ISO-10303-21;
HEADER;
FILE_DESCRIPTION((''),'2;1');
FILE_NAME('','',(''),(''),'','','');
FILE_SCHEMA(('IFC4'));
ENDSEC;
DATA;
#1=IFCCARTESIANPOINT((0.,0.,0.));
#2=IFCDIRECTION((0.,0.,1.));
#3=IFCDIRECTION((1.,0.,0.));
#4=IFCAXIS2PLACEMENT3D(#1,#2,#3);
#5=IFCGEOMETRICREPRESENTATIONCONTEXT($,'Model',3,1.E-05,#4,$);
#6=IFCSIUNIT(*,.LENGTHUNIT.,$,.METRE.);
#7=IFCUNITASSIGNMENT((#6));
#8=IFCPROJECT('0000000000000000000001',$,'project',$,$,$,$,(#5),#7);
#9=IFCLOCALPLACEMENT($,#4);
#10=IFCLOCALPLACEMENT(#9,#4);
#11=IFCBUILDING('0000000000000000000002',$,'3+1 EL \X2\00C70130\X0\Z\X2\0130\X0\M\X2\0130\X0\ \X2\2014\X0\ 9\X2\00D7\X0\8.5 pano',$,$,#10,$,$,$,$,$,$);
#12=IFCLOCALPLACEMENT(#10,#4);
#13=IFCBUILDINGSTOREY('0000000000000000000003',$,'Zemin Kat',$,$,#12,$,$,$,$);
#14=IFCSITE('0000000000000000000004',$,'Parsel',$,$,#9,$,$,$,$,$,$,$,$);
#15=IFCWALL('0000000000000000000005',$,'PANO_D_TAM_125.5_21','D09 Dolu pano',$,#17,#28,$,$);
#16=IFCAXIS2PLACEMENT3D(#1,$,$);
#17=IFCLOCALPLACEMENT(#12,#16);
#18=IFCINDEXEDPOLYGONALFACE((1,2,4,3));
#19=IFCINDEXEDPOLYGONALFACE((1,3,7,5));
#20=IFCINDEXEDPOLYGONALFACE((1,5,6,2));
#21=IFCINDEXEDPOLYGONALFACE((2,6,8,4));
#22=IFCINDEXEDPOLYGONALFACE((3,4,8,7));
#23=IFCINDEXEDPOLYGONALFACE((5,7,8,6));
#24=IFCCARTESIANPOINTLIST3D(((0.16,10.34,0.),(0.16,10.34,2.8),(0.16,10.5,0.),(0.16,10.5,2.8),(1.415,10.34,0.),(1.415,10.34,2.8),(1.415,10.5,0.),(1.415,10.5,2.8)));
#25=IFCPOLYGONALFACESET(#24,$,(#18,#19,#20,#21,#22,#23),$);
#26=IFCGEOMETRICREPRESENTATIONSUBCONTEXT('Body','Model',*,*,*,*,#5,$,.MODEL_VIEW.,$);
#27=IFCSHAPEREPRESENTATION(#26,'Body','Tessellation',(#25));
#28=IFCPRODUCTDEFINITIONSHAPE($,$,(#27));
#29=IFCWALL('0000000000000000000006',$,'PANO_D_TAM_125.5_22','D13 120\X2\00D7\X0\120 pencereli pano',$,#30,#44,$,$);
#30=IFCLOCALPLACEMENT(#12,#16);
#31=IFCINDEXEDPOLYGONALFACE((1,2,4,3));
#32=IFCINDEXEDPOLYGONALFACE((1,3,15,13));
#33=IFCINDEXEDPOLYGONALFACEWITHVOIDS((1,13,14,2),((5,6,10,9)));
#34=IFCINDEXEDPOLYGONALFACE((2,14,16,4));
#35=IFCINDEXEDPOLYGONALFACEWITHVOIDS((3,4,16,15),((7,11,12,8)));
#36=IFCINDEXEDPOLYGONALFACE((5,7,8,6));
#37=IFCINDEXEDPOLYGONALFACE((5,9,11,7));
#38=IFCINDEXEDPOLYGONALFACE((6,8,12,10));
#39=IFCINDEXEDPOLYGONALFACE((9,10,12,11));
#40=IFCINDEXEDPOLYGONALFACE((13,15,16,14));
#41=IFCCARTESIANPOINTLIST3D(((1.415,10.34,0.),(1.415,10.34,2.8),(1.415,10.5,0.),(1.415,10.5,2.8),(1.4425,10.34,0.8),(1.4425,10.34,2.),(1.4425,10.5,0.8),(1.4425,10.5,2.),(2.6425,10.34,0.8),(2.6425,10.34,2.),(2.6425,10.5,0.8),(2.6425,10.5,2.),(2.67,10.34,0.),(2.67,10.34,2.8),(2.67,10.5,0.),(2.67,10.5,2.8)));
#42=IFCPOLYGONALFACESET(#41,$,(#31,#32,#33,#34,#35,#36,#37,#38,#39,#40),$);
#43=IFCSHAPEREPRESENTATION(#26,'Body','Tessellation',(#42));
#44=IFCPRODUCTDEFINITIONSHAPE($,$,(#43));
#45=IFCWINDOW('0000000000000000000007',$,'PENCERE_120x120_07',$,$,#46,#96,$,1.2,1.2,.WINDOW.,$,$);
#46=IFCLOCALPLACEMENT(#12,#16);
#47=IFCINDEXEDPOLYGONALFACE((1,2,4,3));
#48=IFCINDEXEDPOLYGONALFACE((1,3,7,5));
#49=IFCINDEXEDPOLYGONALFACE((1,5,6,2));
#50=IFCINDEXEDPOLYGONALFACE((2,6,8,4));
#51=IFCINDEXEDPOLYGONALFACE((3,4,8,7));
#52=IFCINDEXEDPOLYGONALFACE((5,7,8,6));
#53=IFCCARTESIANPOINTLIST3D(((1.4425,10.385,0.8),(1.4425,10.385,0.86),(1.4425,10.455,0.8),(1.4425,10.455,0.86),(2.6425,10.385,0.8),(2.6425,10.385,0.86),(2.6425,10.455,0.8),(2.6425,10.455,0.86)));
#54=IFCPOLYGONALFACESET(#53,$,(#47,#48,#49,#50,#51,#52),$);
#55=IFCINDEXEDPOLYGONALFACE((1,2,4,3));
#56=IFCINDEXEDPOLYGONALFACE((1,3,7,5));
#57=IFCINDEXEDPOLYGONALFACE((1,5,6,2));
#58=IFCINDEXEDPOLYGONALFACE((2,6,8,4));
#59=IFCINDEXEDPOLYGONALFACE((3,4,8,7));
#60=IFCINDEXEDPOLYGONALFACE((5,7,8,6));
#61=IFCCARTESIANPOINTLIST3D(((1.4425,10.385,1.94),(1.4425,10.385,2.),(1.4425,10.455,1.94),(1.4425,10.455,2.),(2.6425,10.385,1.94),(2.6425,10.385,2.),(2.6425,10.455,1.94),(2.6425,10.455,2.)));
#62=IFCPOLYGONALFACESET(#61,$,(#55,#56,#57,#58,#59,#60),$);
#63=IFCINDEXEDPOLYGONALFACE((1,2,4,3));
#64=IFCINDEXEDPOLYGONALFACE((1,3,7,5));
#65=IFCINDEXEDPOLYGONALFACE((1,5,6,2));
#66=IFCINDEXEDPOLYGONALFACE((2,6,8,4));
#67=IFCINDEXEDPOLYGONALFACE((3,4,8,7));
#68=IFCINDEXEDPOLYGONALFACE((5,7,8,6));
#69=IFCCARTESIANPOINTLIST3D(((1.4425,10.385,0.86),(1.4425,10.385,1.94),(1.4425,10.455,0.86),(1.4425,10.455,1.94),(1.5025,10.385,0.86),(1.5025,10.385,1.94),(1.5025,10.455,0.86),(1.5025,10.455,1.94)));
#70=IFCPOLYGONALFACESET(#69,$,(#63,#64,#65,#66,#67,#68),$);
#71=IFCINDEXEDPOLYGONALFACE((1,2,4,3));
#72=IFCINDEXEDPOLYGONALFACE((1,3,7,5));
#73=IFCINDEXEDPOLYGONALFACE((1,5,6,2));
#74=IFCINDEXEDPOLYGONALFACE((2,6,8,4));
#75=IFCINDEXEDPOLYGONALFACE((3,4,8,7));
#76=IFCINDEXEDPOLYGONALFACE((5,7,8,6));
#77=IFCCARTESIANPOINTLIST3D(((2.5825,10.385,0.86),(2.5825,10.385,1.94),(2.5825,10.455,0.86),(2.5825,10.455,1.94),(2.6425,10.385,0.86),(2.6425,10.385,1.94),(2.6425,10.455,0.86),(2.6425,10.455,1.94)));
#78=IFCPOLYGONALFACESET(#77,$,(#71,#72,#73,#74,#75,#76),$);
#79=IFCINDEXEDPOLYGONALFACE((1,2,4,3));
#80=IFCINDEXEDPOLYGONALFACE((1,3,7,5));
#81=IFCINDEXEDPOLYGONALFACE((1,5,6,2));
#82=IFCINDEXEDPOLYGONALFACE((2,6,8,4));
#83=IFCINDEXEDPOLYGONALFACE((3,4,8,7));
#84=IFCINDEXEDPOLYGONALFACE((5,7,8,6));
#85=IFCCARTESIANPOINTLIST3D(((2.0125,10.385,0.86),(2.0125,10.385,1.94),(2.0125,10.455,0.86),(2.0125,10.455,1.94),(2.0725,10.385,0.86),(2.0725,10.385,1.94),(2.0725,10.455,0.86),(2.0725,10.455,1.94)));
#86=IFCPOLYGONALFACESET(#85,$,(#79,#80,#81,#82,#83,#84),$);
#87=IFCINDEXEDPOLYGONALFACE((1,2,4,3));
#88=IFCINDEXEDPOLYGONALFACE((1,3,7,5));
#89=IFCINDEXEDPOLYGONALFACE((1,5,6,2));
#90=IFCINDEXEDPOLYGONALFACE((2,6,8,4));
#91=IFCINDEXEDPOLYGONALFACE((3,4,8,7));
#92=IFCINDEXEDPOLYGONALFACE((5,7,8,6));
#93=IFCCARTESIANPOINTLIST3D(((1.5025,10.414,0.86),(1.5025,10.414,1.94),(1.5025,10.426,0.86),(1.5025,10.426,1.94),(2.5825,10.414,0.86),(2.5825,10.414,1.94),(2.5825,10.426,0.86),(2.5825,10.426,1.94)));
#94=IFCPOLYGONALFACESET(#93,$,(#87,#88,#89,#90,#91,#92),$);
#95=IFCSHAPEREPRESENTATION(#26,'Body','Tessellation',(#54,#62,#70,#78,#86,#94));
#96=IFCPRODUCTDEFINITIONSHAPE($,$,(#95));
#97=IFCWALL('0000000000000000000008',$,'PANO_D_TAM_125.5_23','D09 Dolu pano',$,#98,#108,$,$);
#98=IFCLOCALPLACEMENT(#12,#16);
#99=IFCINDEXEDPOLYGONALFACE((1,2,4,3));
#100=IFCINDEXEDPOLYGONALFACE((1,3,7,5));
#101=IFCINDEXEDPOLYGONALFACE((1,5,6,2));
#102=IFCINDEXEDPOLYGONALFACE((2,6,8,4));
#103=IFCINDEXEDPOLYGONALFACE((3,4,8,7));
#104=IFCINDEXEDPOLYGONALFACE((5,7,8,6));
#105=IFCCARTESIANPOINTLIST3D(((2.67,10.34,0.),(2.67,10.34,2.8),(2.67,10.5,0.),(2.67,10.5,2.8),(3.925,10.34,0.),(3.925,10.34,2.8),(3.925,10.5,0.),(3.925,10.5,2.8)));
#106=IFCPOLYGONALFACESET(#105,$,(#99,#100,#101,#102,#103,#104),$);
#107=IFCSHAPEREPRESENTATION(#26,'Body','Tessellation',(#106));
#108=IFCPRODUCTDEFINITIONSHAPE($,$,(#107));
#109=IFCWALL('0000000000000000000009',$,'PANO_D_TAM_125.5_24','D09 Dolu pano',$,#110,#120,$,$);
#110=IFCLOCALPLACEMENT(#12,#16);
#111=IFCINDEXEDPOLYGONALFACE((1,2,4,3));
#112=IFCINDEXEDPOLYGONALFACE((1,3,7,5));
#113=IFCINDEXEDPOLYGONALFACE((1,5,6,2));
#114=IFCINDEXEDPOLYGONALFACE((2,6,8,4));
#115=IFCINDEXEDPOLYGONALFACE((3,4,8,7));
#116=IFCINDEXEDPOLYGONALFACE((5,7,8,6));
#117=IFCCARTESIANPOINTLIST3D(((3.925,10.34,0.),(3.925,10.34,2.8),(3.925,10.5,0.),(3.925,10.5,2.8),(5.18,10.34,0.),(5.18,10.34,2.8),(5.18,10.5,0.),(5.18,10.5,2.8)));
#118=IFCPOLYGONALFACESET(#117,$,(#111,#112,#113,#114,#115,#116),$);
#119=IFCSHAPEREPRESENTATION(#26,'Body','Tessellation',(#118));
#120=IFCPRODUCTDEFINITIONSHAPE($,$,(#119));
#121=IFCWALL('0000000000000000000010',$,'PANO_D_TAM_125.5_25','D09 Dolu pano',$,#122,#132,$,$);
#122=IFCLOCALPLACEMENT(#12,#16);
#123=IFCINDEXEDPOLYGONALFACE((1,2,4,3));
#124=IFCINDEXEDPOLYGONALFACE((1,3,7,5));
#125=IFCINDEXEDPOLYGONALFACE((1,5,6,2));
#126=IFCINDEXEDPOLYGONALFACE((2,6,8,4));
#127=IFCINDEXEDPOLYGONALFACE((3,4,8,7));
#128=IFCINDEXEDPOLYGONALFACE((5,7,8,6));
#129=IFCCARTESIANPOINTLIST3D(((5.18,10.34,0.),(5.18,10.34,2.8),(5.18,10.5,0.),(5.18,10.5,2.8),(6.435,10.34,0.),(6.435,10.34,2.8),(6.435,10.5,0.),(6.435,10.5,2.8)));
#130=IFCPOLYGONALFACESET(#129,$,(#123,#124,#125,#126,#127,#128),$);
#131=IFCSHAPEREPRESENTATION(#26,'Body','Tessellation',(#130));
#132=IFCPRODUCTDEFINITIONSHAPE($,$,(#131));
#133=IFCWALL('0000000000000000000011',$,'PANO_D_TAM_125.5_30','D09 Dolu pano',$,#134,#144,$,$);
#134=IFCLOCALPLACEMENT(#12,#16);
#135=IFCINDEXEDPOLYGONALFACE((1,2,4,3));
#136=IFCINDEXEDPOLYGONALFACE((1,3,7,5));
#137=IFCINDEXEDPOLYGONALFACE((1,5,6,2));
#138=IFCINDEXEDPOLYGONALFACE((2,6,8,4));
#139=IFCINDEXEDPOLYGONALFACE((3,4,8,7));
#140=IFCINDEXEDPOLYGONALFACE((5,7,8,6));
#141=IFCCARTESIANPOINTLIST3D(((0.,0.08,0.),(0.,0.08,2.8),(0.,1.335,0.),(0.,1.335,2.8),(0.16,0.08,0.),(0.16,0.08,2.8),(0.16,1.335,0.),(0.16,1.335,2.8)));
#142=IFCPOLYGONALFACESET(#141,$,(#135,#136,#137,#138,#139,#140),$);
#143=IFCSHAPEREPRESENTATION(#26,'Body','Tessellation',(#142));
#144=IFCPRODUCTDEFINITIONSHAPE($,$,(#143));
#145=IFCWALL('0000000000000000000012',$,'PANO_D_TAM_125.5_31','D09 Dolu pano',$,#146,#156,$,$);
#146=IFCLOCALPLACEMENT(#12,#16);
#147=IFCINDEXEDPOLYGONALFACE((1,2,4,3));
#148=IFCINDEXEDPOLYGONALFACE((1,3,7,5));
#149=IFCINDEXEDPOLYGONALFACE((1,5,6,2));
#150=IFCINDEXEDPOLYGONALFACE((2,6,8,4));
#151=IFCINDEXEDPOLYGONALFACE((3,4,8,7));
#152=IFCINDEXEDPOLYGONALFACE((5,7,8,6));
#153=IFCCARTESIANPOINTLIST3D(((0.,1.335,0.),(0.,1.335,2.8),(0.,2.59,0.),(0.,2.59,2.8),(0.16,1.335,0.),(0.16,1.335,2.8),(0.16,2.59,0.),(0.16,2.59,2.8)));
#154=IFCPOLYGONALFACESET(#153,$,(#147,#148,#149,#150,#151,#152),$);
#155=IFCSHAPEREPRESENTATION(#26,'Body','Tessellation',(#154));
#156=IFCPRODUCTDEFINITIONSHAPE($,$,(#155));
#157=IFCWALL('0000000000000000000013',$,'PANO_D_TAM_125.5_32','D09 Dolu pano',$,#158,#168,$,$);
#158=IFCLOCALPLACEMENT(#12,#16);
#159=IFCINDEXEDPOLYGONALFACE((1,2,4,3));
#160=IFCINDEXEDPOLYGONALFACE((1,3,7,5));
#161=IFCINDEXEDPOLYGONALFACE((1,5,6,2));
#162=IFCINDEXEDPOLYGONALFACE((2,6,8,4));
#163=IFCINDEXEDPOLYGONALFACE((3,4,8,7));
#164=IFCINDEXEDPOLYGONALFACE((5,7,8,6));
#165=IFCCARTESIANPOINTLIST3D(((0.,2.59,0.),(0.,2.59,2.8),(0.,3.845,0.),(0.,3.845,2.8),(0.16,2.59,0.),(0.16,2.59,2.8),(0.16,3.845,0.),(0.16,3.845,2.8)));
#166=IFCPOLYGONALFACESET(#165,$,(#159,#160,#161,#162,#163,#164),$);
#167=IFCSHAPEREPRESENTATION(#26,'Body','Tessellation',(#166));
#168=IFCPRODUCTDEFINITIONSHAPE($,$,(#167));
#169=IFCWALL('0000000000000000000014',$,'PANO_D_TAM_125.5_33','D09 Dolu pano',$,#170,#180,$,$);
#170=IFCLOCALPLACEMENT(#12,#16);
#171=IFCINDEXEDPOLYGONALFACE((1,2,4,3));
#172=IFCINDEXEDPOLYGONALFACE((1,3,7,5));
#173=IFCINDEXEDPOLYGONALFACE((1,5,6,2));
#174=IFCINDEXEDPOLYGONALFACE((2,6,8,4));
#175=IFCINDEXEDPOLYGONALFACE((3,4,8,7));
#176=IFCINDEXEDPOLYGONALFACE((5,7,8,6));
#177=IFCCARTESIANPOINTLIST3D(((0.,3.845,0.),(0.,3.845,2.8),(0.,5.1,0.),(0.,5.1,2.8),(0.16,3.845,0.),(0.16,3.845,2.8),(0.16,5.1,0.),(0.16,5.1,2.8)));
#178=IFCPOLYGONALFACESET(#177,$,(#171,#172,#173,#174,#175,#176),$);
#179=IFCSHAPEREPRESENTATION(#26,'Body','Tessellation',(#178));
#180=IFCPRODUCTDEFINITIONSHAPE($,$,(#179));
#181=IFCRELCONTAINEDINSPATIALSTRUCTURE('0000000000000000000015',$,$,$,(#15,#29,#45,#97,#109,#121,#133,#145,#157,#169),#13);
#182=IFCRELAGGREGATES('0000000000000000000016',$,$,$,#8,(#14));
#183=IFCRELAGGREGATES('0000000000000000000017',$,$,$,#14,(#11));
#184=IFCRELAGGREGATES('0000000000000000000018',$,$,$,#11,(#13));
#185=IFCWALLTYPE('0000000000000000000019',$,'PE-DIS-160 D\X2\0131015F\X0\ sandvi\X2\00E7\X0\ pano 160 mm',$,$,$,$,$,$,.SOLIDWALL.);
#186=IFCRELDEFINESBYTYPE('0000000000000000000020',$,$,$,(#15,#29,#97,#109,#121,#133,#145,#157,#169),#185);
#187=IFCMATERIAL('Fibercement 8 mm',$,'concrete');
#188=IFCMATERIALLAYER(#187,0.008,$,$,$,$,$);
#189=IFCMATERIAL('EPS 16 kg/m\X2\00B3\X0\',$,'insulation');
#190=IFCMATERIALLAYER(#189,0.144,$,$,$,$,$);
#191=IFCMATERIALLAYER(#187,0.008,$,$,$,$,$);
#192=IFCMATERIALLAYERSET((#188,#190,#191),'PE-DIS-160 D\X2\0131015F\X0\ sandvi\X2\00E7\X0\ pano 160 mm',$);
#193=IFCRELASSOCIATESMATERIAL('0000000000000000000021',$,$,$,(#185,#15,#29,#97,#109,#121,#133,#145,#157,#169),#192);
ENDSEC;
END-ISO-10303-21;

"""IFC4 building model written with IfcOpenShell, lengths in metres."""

from ifc_helpers import new_model, si_unit, frame, origin_with_axes, place, context, subcontext, project, spatial, line, indexed_curve, outline, extrude, material, layer, layer_set, layer_usage, type_object, element, fill, save


model = new_model("IFC4")

# Units and contexts
model_context = context("Model", 3, precision=1e-05, world=origin_with_axes())
body_context = subcontext(model_context, "Body", "Model", "MODEL_VIEW")
ifc_project = project(units=[si_unit("LENGTHUNIT", "METRE")], contexts=[model_context])

# Site, building, storey
site_placement = place(None, origin_with_axes())
site = spatial("IfcSite", under=ifc_project, at=site_placement, Name="Parsel")
building_placement = place(site_placement, origin_with_axes())
building = spatial("IfcBuilding", under=site, at=building_placement, Name="3+1 EL ÇİZİMİ — 9×8.5 pano")
storey_placement = place(building_placement, origin_with_axes())
storey = spatial("IfcBuildingStorey", under=building, at=storey_placement, Name="Zemin Kat")

# Wall
ifc_material_1 = material(Name="Fibercement 8 mm", Category="concrete")
ifc_layer_1 = layer(ifc_material_1, 0.008)
ifc_material_2 = material(Name="EPS 16 kg/m³", Category="insulation")
ifc_layer_2 = layer(ifc_material_2, 0.144)
ifc_layer_3 = layer(ifc_material_1, 0.008)
ifc_layer_set_1 = layer_set([ifc_layer_1, ifc_layer_2, ifc_layer_3], Name="PE-DIS-160 Dış sandviç pano 160 mm")
ifc_layer_usage_1 = layer_usage(ifc_layer_set_1, "AXIS2", "POSITIVE", 0.0)
wall_type_1 = type_object("IfcWallType", Name="PE-DIS-160 Dış sandviç pano 160 mm", PredefinedType="SOLIDWALL", material=ifc_layer_set_1)
wall_1_placement = place(storey_placement, frame((0.16, 10.34, 0.0), z_axis=(0.0, 0.0, 1.0), x_axis=(1.0, 0.0, 0.0)))
element("IfcWall", 1, at=wall_1_placement, inside=storey, type_object=wall_type_1, material=ifc_layer_usage_1, Name="PANO_D_TAM_125.5_21", Description="D09 Dolu pano", context=body_context, shape_type="SweptSolid", body=[
    extrude(outline(indexed_curve([(0.0, 0.0), (1.255, 0.0), (1.255, 0.16), (0.0, 0.16)], segments=[line(1, 2, 3, 4, 1)])), origin_with_axes(), (0.0, 0.0, 1.0), 2.8),
])

# Wall, opening, window
ifc_layer_usage_2 = layer_usage(ifc_layer_set_1, "AXIS2", "POSITIVE", 0.0)
wall_2_placement = place(storey_placement, frame((1.415, 10.34, 0.0), z_axis=(0.0, 0.0, 1.0), x_axis=(1.0, 0.0, 0.0)))
wall_2 = element("IfcWall", 2, at=wall_2_placement, inside=storey, type_object=wall_type_1, material=ifc_layer_usage_2, Name="PANO_D_TAM_125.5_22", Description="D13 120×120 pencereli pano", context=body_context, shape_type="SweptSolid", body=[
    extrude(outline(indexed_curve([(0.0, 0.0), (1.255, 0.0), (1.255, 0.16), (0.0, 0.16)], segments=[line(1, 2, 3, 4, 1)])), origin_with_axes(), (0.0, 0.0, 1.0), 2.8),
])
opening_placement = place(wall_2_placement, origin_with_axes())
opening = element("IfcOpeningElement", 3, at=opening_placement, cuts=wall_2, PredefinedType="OPENING", context=body_context, shape_type="SweptSolid", body=[
    extrude(outline(indexed_curve([(0.0, 0.0), (1.2, 0.0), (1.2, 0.2), (0.0, 0.2)], segments=[line(1, 2, 3, 4, 1)])), frame((0.0275, -0.02, 0.8), z_axis=(0.0, 0.0, 1.0), x_axis=(1.0, 0.0, 0.0)), (0.0, 0.0, 1.0), 1.2),
])
window_placement = place(storey_placement, frame((1.415, 10.34, 0.0), z_axis=(0.0, 0.0, 1.0), x_axis=(1.0, 0.0, 0.0)))
window = element("IfcWindow", 4, at=window_placement, inside=storey, Name="PENCERE_120x120_07", OverallHeight=1.2, OverallWidth=1.2, PredefinedType="WINDOW", context=body_context, shape_type="SweptSolid", body=[
    extrude(outline(indexed_curve([(0.0, 0.0), (1.2, 0.0), (1.2, 0.07), (0.0, 0.07)], segments=[line(1, 2, 3, 4, 1)])), frame((0.0275, 0.045, 0.8), z_axis=(0.0, 0.0, 1.0), x_axis=(1.0, 0.0, 0.0)), (0.0, 0.0, 1.0), 0.06),
    extrude(outline(indexed_curve([(0.0, 0.0), (1.2, 0.0), (1.2, 0.07), (0.0, 0.07)], segments=[line(1, 2, 3, 4, 1)])), frame((0.0275, 0.045, 1.94), z_axis=(0.0, 0.0, 1.0), x_axis=(1.0, 0.0, 0.0)), (0.0, 0.0, 1.0), 0.06),
    extrude(outline(indexed_curve([(0.0, 0.0), (0.06, 0.0), (0.06, 0.07), (0.0, 0.07)], segments=[line(1, 2, 3, 4, 1)])), frame((0.0275, 0.045, 0.86), z_axis=(0.0, 0.0, 1.0), x_axis=(1.0, 0.0, 0.0)), (0.0, 0.0, 1.0), 1.08),
    extrude(outline(indexed_curve([(0.0, 0.0), (0.06, 0.0), (0.06, 0.07), (0.0, 0.07)], segments=[line(1, 2, 3, 4, 1)])), frame((1.1675, 0.045, 0.86), z_axis=(0.0, 0.0, 1.0), x_axis=(1.0, 0.0, 0.0)), (0.0, 0.0, 1.0), 1.08),
    extrude(outline(indexed_curve([(0.0, 0.0), (0.06, 0.0), (0.06, 0.07), (0.0, 0.07)], segments=[line(1, 2, 3, 4, 1)])), frame((0.5975, 0.045, 0.86), z_axis=(0.0, 0.0, 1.0), x_axis=(1.0, 0.0, 0.0)), (0.0, 0.0, 1.0), 1.08),
    extrude(outline(indexed_curve([(0.0, 0.0), (1.08, 0.0), (1.08, 0.012), (0.0, 0.012)], segments=[line(1, 2, 3, 4, 1)])), frame((0.0875, 0.074, 0.86), z_axis=(0.0, 0.0, 1.0), x_axis=(1.0, 0.0, 0.0)), (0.0, 0.0, 1.0), 1.08),
])
fill(opening, window)

# Walls
ifc_layer_usage_3 = layer_usage(ifc_layer_set_1, "AXIS2", "POSITIVE", 0.0)
wall_3_placement = place(storey_placement, frame((2.67, 10.34, 0.0), z_axis=(0.0, 0.0, 1.0), x_axis=(1.0, 0.0, 0.0)))
element("IfcWall", 5, at=wall_3_placement, inside=storey, type_object=wall_type_1, material=ifc_layer_usage_3, Name="PANO_D_TAM_125.5_23", Description="D09 Dolu pano", context=body_context, shape_type="SweptSolid", body=[
    extrude(outline(indexed_curve([(0.0, 0.0), (1.255, 0.0), (1.255, 0.16), (0.0, 0.16)], segments=[line(1, 2, 3, 4, 1)])), origin_with_axes(), (0.0, 0.0, 1.0), 2.8),
])
ifc_layer_usage_4 = layer_usage(ifc_layer_set_1, "AXIS2", "POSITIVE", 0.0)
wall_4_placement = place(storey_placement, frame((3.925, 10.34, 0.0), z_axis=(0.0, 0.0, 1.0), x_axis=(1.0, 0.0, 0.0)))
element("IfcWall", 6, at=wall_4_placement, inside=storey, type_object=wall_type_1, material=ifc_layer_usage_4, Name="PANO_D_TAM_125.5_24", Description="D09 Dolu pano", context=body_context, shape_type="SweptSolid", body=[
    extrude(outline(indexed_curve([(0.0, 0.0), (1.255, 0.0), (1.255, 0.16), (0.0, 0.16)], segments=[line(1, 2, 3, 4, 1)])), origin_with_axes(), (0.0, 0.0, 1.0), 2.8),
])
ifc_layer_usage_5 = layer_usage(ifc_layer_set_1, "AXIS2", "POSITIVE", 0.0)
wall_5_placement = place(storey_placement, frame((5.18, 10.34, 0.0), z_axis=(0.0, 0.0, 1.0), x_axis=(1.0, 0.0, 0.0)))
element("IfcWall", 7, at=wall_5_placement, inside=storey, type_object=wall_type_1, material=ifc_layer_usage_5, Name="PANO_D_TAM_125.5_25", Description="D09 Dolu pano", context=body_context, shape_type="SweptSolid", body=[
    extrude(outline(indexed_curve([(0.0, 0.0), (1.255, 0.0), (1.255, 0.16), (0.0, 0.16)], segments=[line(1, 2, 3, 4, 1)])), origin_with_axes(), (0.0, 0.0, 1.0), 2.8),
])
ifc_layer_usage_6 = layer_usage(ifc_layer_set_1, "AXIS2", "POSITIVE", 0.0)
wall_6_placement = place(storey_placement, frame((0.16, 0.08, 0.0), z_axis=(0.0, 0.0, 1.0), x_axis=(0.0, 1.0, 0.0)))
element("IfcWall", 8, at=wall_6_placement, inside=storey, type_object=wall_type_1, material=ifc_layer_usage_6, Name="PANO_D_TAM_125.5_30", Description="D09 Dolu pano", context=body_context, shape_type="SweptSolid", body=[
    extrude(outline(indexed_curve([(0.0, 0.0), (1.255, 0.0), (1.255, 0.16), (0.0, 0.16)], segments=[line(1, 2, 3, 4, 1)])), origin_with_axes(), (0.0, 0.0, 1.0), 2.8),
])
ifc_layer_usage_7 = layer_usage(ifc_layer_set_1, "AXIS2", "POSITIVE", 0.0)
wall_7_placement = place(storey_placement, frame((0.16, 1.335, 0.0), z_axis=(0.0, 0.0, 1.0), x_axis=(0.0, 1.0, 0.0)))
element("IfcWall", 9, at=wall_7_placement, inside=storey, type_object=wall_type_1, material=ifc_layer_usage_7, Name="PANO_D_TAM_125.5_31", Description="D09 Dolu pano", context=body_context, shape_type="SweptSolid", body=[
    extrude(outline(indexed_curve([(0.0, 0.0), (1.255, 0.0), (1.255, 0.16), (0.0, 0.16)], segments=[line(1, 2, 3, 4, 1)])), origin_with_axes(), (0.0, 0.0, 1.0), 2.8),
])
ifc_layer_usage_8 = layer_usage(ifc_layer_set_1, "AXIS2", "POSITIVE", 0.0)
wall_8_placement = place(storey_placement, frame((0.16, 2.59, 0.0), z_axis=(0.0, 0.0, 1.0), x_axis=(0.0, 1.0, 0.0)))
element("IfcWall", 10, at=wall_8_placement, inside=storey, type_object=wall_type_1, material=ifc_layer_usage_8, Name="PANO_D_TAM_125.5_32", Description="D09 Dolu pano", context=body_context, shape_type="SweptSolid", body=[
    extrude(outline(indexed_curve([(0.0, 0.0), (1.255, 0.0), (1.255, 0.16), (0.0, 0.16)], segments=[line(1, 2, 3, 4, 1)])), origin_with_axes(), (0.0, 0.0, 1.0), 2.8),
])
ifc_layer_usage_9 = layer_usage(ifc_layer_set_1, "AXIS2", "POSITIVE", 0.0)
wall_9_placement = place(storey_placement, frame((0.16, 3.845, 0.0), z_axis=(0.0, 0.0, 1.0), x_axis=(0.0, 1.0, 0.0)))
element("IfcWall", 11, at=wall_9_placement, inside=storey, type_object=wall_type_1, material=ifc_layer_usage_9, Name="PANO_D_TAM_125.5_33", Description="D09 Dolu pano", context=body_context, shape_type="SweptSolid", body=[
    extrude(outline(indexed_curve([(0.0, 0.0), (1.255, 0.0), (1.255, 0.16), (0.0, 0.16)], segments=[line(1, 2, 3, 4, 1)])), origin_with_axes(), (0.0, 0.0, 1.0), 2.8),
])

save(model, "model.ifc")
